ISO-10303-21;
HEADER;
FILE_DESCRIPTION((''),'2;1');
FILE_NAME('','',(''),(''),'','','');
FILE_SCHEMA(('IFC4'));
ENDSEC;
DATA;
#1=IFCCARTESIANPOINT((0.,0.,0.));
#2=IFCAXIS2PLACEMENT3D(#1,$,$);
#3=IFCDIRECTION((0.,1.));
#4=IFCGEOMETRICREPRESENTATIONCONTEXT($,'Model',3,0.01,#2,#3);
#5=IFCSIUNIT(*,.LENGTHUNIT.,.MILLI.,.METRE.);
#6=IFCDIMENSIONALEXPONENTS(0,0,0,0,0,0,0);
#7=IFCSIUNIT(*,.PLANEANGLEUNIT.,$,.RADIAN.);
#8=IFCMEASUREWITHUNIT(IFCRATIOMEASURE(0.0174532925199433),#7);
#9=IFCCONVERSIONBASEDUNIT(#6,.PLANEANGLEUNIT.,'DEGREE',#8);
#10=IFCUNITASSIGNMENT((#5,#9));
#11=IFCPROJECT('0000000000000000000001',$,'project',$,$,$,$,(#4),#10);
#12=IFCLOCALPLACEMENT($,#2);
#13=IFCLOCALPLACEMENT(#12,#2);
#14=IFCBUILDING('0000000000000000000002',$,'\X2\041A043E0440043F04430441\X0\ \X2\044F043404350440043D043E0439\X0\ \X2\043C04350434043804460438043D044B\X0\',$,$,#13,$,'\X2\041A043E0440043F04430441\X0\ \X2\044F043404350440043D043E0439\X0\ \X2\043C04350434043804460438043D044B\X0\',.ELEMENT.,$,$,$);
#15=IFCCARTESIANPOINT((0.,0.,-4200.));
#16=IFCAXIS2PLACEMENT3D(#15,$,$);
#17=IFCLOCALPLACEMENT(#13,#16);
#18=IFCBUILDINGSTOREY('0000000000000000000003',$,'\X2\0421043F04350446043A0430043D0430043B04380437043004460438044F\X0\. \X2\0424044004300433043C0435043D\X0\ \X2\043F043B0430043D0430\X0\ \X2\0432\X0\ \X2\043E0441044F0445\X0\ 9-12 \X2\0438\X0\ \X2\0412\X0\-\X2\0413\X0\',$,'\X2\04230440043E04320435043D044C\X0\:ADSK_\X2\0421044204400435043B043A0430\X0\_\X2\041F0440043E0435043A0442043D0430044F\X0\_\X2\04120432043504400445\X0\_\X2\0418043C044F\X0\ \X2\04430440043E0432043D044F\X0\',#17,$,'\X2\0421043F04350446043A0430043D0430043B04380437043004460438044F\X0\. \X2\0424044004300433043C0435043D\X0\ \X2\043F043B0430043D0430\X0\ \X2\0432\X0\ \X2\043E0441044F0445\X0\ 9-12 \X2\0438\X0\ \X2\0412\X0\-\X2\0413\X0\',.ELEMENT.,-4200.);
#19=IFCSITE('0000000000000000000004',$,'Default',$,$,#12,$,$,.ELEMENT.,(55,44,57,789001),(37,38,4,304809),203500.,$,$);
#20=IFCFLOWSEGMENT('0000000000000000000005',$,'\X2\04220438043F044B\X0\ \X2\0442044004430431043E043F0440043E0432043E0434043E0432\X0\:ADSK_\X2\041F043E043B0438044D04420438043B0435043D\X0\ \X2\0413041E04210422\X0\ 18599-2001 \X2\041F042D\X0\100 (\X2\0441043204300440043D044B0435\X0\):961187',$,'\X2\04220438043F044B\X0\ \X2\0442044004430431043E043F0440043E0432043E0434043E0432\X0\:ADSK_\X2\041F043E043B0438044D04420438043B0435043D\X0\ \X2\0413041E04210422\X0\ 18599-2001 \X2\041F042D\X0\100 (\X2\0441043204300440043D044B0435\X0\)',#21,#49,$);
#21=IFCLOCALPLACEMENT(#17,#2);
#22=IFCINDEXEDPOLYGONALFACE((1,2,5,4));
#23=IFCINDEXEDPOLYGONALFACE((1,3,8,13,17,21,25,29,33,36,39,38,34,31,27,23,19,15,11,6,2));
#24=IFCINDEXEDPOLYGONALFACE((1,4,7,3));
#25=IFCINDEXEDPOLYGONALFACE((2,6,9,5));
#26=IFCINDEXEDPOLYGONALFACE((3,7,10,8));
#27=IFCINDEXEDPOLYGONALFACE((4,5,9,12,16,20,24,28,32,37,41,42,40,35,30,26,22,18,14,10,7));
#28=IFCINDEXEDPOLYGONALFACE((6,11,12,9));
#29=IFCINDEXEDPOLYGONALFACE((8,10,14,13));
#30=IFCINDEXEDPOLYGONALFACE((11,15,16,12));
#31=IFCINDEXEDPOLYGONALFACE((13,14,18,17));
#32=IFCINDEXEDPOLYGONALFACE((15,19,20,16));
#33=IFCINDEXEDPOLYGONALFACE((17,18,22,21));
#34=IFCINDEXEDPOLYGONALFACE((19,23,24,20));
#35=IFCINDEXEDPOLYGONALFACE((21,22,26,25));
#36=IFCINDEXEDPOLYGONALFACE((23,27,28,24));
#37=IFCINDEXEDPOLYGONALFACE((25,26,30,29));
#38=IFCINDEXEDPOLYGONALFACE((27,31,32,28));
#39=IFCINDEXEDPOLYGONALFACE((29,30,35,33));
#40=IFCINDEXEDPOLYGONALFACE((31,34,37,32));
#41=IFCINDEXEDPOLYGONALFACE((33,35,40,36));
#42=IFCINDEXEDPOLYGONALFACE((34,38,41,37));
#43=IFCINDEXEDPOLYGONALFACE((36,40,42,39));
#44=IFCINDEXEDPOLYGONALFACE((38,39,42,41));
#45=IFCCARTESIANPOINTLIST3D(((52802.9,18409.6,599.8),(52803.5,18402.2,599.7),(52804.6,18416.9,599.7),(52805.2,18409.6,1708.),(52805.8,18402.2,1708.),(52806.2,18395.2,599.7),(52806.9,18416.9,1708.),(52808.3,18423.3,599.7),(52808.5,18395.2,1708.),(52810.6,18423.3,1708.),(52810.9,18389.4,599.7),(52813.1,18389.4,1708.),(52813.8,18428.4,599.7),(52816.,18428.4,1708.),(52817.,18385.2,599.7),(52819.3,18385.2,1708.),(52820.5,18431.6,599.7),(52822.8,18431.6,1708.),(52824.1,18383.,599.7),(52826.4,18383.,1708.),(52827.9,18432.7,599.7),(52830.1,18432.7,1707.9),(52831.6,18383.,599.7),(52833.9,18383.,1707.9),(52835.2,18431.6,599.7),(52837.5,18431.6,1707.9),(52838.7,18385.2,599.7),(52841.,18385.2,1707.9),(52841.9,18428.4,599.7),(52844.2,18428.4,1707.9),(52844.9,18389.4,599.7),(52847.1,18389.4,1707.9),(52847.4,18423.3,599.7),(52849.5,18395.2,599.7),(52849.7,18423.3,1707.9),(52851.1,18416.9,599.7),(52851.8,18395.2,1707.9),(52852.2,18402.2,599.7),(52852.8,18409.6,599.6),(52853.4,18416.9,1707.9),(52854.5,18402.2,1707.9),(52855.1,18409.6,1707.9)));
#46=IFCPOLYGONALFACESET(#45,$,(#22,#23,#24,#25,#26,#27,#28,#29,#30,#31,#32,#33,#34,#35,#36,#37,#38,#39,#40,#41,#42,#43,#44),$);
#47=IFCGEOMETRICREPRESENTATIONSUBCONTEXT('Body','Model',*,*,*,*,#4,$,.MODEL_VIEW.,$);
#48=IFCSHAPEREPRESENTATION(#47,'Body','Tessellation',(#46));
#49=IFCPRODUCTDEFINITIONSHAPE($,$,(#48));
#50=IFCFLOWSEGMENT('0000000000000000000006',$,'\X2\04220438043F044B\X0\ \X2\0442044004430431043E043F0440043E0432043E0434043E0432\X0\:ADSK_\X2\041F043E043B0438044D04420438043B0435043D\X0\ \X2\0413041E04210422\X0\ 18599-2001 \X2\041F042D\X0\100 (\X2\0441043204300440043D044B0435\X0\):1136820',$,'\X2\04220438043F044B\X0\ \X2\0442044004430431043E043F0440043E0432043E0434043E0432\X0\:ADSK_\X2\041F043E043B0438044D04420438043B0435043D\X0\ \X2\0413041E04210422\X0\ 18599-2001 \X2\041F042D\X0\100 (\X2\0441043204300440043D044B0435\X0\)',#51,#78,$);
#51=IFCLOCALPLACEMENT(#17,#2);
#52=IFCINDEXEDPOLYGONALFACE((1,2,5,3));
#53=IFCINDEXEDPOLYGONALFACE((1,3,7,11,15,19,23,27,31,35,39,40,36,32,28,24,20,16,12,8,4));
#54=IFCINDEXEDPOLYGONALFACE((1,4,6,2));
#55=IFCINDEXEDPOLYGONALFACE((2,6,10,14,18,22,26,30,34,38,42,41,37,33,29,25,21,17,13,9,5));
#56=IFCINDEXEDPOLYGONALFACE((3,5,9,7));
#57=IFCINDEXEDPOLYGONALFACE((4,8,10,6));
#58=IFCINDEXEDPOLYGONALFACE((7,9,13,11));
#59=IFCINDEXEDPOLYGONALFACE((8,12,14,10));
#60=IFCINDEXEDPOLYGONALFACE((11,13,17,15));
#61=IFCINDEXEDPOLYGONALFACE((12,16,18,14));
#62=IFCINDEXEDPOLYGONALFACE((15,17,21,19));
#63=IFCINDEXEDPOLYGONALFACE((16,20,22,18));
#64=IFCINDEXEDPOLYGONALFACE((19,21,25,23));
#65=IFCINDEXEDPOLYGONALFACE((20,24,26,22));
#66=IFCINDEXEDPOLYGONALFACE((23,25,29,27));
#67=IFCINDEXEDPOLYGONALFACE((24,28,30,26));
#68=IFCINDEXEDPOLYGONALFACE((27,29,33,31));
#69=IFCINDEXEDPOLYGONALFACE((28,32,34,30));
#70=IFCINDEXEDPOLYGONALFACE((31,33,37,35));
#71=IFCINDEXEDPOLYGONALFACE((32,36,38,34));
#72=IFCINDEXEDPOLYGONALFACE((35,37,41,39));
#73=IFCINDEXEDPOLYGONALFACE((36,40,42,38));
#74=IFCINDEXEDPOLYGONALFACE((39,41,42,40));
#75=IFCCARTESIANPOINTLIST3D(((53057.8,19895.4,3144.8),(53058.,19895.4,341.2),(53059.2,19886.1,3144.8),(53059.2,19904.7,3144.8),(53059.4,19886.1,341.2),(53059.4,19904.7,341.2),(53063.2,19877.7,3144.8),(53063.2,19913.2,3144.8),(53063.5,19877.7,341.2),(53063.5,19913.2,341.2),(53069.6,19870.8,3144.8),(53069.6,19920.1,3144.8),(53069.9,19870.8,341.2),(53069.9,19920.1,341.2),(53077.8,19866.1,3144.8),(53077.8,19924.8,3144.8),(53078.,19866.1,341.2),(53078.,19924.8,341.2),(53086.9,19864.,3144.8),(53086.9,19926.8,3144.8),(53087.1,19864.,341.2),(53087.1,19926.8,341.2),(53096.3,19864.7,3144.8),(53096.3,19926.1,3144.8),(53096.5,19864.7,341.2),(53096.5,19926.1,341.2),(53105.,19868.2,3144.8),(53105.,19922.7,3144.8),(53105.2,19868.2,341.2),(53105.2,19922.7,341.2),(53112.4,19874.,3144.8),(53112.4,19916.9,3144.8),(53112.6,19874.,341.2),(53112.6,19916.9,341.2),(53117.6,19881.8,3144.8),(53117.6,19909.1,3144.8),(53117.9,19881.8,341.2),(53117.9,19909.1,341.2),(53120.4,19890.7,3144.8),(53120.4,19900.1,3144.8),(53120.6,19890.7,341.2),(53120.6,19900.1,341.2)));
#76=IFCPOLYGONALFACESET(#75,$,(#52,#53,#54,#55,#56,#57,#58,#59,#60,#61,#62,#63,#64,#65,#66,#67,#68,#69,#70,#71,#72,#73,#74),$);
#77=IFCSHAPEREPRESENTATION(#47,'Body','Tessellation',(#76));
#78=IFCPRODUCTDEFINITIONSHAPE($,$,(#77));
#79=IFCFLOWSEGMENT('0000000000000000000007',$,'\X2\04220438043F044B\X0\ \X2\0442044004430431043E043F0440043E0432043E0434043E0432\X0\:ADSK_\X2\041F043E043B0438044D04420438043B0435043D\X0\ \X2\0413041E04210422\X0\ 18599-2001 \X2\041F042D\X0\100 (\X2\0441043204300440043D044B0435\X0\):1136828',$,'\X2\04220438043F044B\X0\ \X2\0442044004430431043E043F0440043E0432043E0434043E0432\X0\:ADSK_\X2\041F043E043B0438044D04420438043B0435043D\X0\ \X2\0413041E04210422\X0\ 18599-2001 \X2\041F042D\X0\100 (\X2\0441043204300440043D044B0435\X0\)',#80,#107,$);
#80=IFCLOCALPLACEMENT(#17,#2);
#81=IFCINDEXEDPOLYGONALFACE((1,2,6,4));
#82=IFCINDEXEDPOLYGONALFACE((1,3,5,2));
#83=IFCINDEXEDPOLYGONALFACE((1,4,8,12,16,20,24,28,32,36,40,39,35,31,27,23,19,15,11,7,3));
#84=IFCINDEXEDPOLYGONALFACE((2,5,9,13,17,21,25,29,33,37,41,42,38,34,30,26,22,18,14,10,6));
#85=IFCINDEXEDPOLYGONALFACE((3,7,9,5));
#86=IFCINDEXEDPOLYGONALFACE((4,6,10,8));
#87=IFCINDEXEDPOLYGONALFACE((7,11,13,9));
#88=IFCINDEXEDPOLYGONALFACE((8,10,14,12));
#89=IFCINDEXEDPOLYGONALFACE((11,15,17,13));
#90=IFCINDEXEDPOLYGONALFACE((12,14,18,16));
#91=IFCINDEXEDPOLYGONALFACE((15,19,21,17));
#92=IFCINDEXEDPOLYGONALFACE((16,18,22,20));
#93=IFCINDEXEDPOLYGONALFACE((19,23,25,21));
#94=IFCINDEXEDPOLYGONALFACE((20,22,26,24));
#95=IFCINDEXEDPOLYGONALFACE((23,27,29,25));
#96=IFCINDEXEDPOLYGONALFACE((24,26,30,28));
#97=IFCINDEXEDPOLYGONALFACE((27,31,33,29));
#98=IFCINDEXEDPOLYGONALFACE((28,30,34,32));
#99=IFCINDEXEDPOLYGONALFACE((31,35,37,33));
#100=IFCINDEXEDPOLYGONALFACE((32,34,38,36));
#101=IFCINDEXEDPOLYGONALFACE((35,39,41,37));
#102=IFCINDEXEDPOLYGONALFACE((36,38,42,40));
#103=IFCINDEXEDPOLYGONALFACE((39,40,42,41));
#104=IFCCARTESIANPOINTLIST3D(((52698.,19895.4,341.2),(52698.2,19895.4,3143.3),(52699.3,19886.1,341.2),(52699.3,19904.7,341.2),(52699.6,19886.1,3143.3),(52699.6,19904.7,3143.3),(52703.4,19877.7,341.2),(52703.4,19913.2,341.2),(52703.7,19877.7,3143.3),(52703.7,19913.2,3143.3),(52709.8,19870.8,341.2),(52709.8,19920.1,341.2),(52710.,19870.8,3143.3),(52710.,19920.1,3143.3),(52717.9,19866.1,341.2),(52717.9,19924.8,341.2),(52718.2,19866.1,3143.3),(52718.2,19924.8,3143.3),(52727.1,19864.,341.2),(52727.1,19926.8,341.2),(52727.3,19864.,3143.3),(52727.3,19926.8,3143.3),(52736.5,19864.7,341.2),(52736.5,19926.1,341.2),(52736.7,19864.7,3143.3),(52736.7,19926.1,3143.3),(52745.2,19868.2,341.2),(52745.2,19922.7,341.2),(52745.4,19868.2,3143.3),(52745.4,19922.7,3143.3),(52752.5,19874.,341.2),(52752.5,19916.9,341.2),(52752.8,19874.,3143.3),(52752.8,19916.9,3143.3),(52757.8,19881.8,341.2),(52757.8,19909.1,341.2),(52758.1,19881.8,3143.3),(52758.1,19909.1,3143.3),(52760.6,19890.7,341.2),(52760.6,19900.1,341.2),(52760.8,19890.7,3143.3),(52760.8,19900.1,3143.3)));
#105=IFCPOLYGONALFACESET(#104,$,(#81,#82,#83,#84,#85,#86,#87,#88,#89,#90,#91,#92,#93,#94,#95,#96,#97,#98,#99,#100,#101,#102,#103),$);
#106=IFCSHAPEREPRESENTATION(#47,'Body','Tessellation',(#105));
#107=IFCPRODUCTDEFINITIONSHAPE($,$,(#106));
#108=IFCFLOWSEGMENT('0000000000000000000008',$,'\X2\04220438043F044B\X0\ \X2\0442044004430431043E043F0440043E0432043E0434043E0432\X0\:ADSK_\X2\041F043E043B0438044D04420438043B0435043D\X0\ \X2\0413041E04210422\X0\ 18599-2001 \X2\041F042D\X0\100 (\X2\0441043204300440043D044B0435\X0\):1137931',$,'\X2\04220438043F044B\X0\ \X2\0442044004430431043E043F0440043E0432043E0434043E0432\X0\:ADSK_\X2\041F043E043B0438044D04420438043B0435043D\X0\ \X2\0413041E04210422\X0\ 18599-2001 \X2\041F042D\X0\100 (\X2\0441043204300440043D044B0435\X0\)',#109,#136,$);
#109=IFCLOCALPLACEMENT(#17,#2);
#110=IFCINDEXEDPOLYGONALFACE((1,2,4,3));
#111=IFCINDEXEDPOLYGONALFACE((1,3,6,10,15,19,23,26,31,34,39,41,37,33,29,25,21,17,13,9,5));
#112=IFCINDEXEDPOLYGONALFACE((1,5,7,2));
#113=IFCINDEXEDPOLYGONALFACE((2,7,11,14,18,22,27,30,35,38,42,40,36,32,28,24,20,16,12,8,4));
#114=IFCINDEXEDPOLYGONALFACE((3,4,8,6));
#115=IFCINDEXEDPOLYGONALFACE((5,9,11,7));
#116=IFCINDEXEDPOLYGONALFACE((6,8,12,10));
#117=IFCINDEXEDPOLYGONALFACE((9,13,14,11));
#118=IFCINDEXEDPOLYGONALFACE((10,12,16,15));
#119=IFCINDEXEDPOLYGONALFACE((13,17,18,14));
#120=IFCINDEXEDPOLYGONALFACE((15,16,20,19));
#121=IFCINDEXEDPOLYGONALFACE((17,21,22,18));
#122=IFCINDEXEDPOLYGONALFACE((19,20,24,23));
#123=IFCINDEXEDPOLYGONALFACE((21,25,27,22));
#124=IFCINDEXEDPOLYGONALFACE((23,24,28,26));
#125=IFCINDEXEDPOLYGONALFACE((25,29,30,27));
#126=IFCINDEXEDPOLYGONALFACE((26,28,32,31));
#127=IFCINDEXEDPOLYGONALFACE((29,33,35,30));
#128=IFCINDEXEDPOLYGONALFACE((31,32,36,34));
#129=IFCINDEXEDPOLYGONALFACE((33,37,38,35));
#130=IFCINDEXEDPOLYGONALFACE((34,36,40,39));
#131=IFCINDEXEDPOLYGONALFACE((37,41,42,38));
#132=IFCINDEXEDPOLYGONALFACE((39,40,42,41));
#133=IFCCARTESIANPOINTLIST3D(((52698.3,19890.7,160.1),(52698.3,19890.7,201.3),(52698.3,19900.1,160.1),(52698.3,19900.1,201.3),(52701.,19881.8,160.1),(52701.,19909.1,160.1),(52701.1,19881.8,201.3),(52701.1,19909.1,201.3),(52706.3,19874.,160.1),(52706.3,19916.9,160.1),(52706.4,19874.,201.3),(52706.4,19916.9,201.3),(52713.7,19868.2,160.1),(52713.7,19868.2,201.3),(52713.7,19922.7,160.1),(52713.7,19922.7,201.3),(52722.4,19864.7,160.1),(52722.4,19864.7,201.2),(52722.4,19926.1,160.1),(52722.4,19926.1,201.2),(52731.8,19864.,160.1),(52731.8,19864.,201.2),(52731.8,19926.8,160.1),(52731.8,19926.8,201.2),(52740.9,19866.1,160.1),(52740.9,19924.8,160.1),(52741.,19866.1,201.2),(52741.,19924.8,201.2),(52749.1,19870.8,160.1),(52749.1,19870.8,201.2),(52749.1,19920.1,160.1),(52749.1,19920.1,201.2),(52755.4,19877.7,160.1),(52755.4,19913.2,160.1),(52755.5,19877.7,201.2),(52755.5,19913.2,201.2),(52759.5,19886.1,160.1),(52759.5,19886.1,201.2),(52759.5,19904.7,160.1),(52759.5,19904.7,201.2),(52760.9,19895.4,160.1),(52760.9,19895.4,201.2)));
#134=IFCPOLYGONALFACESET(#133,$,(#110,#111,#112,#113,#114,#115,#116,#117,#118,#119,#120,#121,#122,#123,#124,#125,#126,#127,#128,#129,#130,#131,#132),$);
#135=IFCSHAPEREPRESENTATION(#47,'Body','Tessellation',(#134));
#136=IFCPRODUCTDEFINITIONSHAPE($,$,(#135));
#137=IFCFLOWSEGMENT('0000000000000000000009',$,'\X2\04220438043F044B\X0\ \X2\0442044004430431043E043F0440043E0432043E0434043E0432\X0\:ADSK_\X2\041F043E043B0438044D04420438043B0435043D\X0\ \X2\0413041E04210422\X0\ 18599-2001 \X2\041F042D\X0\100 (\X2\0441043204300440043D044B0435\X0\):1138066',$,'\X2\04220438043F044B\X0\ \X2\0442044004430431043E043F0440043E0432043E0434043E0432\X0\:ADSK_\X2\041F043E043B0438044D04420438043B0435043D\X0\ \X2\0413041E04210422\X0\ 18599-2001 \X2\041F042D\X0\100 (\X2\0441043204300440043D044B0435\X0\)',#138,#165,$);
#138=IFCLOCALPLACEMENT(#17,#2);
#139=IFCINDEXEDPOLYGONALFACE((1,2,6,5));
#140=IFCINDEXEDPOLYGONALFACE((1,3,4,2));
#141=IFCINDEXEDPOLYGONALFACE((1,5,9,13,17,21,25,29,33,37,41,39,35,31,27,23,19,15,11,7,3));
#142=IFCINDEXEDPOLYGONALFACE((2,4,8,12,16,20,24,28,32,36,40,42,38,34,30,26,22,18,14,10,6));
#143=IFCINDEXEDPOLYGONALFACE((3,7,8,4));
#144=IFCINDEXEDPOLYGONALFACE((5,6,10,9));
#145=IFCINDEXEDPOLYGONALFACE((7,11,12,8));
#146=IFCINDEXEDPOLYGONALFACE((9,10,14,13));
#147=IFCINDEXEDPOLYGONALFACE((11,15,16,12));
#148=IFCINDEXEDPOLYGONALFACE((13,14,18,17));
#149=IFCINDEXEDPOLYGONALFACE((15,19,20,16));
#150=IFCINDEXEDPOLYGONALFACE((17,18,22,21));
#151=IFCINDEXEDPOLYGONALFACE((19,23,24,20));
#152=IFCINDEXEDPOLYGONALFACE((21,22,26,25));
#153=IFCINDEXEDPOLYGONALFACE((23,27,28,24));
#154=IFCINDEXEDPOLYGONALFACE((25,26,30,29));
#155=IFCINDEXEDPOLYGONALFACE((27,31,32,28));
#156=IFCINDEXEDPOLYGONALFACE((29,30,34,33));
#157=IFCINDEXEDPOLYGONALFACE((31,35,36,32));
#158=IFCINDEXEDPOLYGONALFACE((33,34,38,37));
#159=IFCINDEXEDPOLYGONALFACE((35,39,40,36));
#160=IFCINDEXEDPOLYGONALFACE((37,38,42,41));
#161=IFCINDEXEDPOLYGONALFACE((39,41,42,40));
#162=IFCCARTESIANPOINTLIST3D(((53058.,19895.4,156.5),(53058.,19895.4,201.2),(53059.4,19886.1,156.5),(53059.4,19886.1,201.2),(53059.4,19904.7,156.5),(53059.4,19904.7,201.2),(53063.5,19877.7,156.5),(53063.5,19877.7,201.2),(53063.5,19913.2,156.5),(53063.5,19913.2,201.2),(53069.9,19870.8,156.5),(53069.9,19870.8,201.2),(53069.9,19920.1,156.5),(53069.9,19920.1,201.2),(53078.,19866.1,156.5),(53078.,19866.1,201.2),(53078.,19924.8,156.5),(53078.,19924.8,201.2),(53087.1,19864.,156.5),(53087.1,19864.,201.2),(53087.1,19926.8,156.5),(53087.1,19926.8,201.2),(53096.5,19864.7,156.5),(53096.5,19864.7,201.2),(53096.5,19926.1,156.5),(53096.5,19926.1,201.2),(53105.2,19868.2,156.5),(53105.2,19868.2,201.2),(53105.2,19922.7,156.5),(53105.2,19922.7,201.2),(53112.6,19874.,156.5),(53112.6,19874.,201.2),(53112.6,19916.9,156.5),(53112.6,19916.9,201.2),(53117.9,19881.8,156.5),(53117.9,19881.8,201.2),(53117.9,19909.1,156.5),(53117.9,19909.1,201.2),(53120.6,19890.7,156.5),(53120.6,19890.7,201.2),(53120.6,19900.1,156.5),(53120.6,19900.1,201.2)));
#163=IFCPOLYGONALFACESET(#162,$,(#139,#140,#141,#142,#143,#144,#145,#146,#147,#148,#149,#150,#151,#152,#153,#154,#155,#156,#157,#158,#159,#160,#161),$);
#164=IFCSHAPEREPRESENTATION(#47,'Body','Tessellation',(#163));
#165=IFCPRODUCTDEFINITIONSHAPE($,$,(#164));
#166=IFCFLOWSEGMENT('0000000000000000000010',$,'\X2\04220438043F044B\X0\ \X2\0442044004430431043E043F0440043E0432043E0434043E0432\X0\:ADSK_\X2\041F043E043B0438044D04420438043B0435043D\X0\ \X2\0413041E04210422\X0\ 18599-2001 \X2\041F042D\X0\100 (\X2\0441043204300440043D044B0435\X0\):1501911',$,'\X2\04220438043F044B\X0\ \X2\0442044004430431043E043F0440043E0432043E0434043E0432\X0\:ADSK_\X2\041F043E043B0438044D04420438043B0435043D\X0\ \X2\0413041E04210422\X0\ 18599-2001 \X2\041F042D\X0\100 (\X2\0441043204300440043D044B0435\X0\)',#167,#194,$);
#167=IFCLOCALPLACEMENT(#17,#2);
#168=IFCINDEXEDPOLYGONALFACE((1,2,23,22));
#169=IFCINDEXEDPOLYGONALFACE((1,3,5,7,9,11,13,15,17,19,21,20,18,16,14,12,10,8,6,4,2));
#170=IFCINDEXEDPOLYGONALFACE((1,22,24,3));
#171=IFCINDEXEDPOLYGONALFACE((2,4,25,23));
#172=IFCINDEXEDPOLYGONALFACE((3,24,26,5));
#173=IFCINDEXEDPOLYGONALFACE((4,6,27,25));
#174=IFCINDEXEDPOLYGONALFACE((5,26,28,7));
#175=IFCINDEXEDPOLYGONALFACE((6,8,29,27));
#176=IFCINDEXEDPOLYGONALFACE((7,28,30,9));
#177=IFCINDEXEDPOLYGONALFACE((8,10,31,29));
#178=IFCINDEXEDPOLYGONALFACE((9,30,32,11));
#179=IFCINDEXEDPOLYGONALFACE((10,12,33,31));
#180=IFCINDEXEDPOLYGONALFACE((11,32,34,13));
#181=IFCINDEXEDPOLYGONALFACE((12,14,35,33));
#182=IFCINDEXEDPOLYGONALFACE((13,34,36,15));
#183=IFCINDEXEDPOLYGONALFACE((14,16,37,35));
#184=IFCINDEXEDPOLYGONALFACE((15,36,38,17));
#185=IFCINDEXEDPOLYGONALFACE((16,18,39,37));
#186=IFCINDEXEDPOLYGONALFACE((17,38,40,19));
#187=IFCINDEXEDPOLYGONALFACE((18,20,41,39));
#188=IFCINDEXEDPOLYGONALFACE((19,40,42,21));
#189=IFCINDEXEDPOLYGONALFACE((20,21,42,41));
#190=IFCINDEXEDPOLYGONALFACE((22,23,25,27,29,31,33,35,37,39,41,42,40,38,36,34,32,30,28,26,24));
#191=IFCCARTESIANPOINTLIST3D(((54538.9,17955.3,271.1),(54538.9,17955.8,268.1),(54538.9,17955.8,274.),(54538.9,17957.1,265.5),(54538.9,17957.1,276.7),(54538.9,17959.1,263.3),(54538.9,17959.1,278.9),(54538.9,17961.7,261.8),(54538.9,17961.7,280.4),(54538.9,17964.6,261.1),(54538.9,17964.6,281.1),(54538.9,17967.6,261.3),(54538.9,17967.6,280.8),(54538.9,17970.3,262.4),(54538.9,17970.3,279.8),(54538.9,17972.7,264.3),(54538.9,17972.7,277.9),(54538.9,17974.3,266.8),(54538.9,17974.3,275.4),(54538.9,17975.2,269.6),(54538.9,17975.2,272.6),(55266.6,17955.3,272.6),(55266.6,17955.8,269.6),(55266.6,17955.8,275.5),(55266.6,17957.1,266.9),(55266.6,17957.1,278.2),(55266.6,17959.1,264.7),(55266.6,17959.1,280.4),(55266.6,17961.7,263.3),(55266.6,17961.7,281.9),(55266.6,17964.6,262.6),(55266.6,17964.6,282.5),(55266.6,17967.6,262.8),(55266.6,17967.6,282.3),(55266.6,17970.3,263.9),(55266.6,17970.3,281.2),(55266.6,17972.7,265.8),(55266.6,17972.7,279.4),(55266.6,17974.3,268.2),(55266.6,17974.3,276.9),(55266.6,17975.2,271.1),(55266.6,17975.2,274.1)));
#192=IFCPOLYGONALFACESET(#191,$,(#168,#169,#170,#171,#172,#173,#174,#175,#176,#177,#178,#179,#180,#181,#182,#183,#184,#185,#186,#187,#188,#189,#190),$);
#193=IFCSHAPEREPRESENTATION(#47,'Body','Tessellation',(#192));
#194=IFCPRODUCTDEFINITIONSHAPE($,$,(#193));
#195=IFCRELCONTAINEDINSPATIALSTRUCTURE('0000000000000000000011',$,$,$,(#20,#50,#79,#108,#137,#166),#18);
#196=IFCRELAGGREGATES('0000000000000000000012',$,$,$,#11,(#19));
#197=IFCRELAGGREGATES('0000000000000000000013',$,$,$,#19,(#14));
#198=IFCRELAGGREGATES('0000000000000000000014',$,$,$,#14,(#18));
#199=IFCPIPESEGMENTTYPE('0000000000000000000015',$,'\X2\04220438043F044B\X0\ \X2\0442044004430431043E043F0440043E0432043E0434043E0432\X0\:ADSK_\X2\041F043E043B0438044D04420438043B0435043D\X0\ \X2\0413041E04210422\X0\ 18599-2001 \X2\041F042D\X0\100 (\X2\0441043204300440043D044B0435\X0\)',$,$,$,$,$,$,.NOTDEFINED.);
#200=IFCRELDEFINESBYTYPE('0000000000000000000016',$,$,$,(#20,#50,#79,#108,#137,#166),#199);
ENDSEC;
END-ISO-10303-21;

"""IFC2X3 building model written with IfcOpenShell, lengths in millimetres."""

from ifc_helpers import new_model, entity, si_unit, converted_unit, direction, frame, origin, origin_2d_with_axis, place, context, subcontext, project, spatial, circle, extrude, type_object, element, save


model = new_model("IFC2X3")

# Units and contexts
model_context = context("Model", 3, precision=0.01, world=origin(), true_north=direction((0.0, 1.0)))
body_context = subcontext(model_context, "Body", "Model", "MODEL_VIEW")
ifc_project = project(units=[si_unit("LENGTHUNIT", "METRE", prefix="MILLI"), converted_unit("PLANEANGLEUNIT", "DEGREE", entity("IfcRatioMeasure", 0.0174532925199433), si_unit("PLANEANGLEUNIT", "RADIAN"), dimensions=[0, 0, 0, 0, 0, 0, 0])], contexts=[model_context])

# Site, building, storey
site_placement = place(None, origin())
site = spatial("IfcSite", under=ifc_project, at=site_placement, Name="Default", CompositionType="ELEMENT", RefLatitude=(55, 44, 57, 789001), RefLongitude=(37, 38, 4, 304809), RefElevation=203500.0)
building_placement = place(site_placement, origin())
building = spatial("IfcBuilding", under=site, at=building_placement, Name="Корпус ядерной медицины", LongName="Корпус ядерной медицины", CompositionType="ELEMENT")
storey_placement = place(building_placement, frame((0.0, 0.0, -4200.0)))
storey = spatial("IfcBuildingStorey", under=building, at=storey_placement, Name="Спецканализация. Фрагмен плана в осях 9-12 и В-Г", ObjectType="Уровень:ADSK_Стрелка_Проектная_Вверх_Имя уровня", LongName="Спецканализация. Фрагмен плана в осях 9-12 и В-Г", CompositionType="ELEMENT", Elevation=-4200.0)

# Flow segments
pipe_segment_type = type_object("IfcPipeSegmentType", Name="Типы трубопроводов:ADSK_Полиэтилен ГОСТ 18599-2001 ПЭ100 (сварные)", PredefinedType="NOTDEFINED")
flow_segment_1_placement = place(storey_placement, frame((52801.3, 18381.1, 599.6)))
element("IfcFlowSegment", 1, at=flow_segment_1_placement, inside=storey, type_object=pipe_segment_type, Name="Типы трубопроводов:ADSK_Полиэтилен ГОСТ 18599-2001 ПЭ100 (сварные):961187", ObjectType="Типы трубопроводов:ADSK_Полиэтилен ГОСТ 18599-2001 ПЭ100 (сварные)", context=body_context, shape_type="SweptSolid", body=[
    extrude(circle(Radius=25.0, at=origin_2d_with_axis()), frame((26.6, 26.6, 0.1), z_axis=(0.002045, 0.000001, 0.999998), x_axis=(-0.000266, 1.0, 0.0)), (0.0, 0.0, 1.0), 1108.3),
])
flow_segment_2_placement = place(storey_placement, frame((53056.2, 19862.3, 341.2)))
element("IfcFlowSegment", 2, at=flow_segment_2_placement, inside=storey, type_object=pipe_segment_type, Name="Типы трубопроводов:ADSK_Полиэтилен ГОСТ 18599-2001 ПЭ100 (сварные):1136820", ObjectType="Типы трубопроводов:ADSK_Полиэтилен ГОСТ 18599-2001 ПЭ100 (сварные)", context=body_context, shape_type="SweptSolid", body=[
    extrude(circle(Radius=31.5, at=origin_2d_with_axis()), frame((33.3, 33.1, 0.0), z_axis=(-0.00008, 0.0, 1.0), x_axis=(-1.0, 0.0, -0.00008)), (0.0, 0.0, 1.0), 2803.6),
])
flow_segment_3_placement = place(storey_placement, frame((52696.3, 19862.3, 341.2)))
element("IfcFlowSegment", 3, at=flow_segment_3_placement, inside=storey, type_object=pipe_segment_type, Name="Типы трубопроводов:ADSK_Полиэтилен ГОСТ 18599-2001 ПЭ100 (сварные):1136828", ObjectType="Типы трубопроводов:ADSK_Полиэтилен ГОСТ 18599-2001 ПЭ100 (сварные)", context=body_context, shape_type="SweptSolid", body=[
    extrude(circle(Radius=31.5, at=origin_2d_with_axis()), frame((33.1, 33.1, 0.0), z_axis=(0.000084, 0.0, 1.0), x_axis=(-1.0, 0.0, 0.000084)), (0.0, 0.0, 1.0), 2802.1),
])
flow_segment_4_placement = place(storey_placement, frame((52696.3, 19862.3, 160.1)))
element("IfcFlowSegment", 4, at=flow_segment_4_placement, inside=storey, type_object=pipe_segment_type, Name="Типы трубопроводов:ADSK_Полиэтилен ГОСТ 18599-2001 ПЭ100 (сварные):1137931", ObjectType="Типы трубопроводов:ADSK_Полиэтилен ГОСТ 18599-2001 ПЭ100 (сварные)", context=body_context, shape_type="SweptSolid", body=[
    extrude(circle(Radius=31.5, at=origin_2d_with_axis()), frame((33.1, 33.1, 0.0), z_axis=(0.000569, 0.0, 1.0), x_axis=(1.0, 0.0, -0.000569)), (0.0, 0.0, 1.0), 41.1),
])
flow_segment_5_placement = place(storey_placement, frame((53056.4, 19862.3, 156.5)))
element("IfcFlowSegment", 5, at=flow_segment_5_placement, inside=storey, type_object=pipe_segment_type, Name="Типы трубопроводов:ADSK_Полиэтилен ГОСТ 18599-2001 ПЭ100 (сварные):1138066", ObjectType="Типы трубопроводов:ADSK_Полиэтилен ГОСТ 18599-2001 ПЭ100 (сварные)", context=body_context, shape_type="SweptSolid", body=[
    extrude(circle(Radius=31.5, at=origin_2d_with_axis()), frame((33.1, 33.1, 0.0), z_axis=(0.000002, 0.0, 1.0), x_axis=(-1.0, 0.0, 0.000002)), (0.0, 0.0, 1.0), 44.7),
])
flow_segment_6_placement = place(storey_placement, frame((54538.9, 17953.7, 259.5)))
element("IfcFlowSegment", 6, at=flow_segment_6_placement, inside=storey, type_object=pipe_segment_type, Name="Типы трубопроводов:ADSK_Полиэтилен ГОСТ 18599-2001 ПЭ100 (сварные):1501911", ObjectType="Типы трубопроводов:ADSK_Полиэтилен ГОСТ 18599-2001 ПЭ100 (сварные)", context=body_context, shape_type="SweptSolid", body=[
    extrude(circle(Radius=10.0, at=origin_2d_with_axis()), frame((0.0, 11.6, 11.6), z_axis=(0.999998, 0.000004, 0.002027), x_axis=(0.000004, -1.0, 0.0)), (0.0, 0.0, 1.0), 727.7),
])

save(model, "model.ifc")
